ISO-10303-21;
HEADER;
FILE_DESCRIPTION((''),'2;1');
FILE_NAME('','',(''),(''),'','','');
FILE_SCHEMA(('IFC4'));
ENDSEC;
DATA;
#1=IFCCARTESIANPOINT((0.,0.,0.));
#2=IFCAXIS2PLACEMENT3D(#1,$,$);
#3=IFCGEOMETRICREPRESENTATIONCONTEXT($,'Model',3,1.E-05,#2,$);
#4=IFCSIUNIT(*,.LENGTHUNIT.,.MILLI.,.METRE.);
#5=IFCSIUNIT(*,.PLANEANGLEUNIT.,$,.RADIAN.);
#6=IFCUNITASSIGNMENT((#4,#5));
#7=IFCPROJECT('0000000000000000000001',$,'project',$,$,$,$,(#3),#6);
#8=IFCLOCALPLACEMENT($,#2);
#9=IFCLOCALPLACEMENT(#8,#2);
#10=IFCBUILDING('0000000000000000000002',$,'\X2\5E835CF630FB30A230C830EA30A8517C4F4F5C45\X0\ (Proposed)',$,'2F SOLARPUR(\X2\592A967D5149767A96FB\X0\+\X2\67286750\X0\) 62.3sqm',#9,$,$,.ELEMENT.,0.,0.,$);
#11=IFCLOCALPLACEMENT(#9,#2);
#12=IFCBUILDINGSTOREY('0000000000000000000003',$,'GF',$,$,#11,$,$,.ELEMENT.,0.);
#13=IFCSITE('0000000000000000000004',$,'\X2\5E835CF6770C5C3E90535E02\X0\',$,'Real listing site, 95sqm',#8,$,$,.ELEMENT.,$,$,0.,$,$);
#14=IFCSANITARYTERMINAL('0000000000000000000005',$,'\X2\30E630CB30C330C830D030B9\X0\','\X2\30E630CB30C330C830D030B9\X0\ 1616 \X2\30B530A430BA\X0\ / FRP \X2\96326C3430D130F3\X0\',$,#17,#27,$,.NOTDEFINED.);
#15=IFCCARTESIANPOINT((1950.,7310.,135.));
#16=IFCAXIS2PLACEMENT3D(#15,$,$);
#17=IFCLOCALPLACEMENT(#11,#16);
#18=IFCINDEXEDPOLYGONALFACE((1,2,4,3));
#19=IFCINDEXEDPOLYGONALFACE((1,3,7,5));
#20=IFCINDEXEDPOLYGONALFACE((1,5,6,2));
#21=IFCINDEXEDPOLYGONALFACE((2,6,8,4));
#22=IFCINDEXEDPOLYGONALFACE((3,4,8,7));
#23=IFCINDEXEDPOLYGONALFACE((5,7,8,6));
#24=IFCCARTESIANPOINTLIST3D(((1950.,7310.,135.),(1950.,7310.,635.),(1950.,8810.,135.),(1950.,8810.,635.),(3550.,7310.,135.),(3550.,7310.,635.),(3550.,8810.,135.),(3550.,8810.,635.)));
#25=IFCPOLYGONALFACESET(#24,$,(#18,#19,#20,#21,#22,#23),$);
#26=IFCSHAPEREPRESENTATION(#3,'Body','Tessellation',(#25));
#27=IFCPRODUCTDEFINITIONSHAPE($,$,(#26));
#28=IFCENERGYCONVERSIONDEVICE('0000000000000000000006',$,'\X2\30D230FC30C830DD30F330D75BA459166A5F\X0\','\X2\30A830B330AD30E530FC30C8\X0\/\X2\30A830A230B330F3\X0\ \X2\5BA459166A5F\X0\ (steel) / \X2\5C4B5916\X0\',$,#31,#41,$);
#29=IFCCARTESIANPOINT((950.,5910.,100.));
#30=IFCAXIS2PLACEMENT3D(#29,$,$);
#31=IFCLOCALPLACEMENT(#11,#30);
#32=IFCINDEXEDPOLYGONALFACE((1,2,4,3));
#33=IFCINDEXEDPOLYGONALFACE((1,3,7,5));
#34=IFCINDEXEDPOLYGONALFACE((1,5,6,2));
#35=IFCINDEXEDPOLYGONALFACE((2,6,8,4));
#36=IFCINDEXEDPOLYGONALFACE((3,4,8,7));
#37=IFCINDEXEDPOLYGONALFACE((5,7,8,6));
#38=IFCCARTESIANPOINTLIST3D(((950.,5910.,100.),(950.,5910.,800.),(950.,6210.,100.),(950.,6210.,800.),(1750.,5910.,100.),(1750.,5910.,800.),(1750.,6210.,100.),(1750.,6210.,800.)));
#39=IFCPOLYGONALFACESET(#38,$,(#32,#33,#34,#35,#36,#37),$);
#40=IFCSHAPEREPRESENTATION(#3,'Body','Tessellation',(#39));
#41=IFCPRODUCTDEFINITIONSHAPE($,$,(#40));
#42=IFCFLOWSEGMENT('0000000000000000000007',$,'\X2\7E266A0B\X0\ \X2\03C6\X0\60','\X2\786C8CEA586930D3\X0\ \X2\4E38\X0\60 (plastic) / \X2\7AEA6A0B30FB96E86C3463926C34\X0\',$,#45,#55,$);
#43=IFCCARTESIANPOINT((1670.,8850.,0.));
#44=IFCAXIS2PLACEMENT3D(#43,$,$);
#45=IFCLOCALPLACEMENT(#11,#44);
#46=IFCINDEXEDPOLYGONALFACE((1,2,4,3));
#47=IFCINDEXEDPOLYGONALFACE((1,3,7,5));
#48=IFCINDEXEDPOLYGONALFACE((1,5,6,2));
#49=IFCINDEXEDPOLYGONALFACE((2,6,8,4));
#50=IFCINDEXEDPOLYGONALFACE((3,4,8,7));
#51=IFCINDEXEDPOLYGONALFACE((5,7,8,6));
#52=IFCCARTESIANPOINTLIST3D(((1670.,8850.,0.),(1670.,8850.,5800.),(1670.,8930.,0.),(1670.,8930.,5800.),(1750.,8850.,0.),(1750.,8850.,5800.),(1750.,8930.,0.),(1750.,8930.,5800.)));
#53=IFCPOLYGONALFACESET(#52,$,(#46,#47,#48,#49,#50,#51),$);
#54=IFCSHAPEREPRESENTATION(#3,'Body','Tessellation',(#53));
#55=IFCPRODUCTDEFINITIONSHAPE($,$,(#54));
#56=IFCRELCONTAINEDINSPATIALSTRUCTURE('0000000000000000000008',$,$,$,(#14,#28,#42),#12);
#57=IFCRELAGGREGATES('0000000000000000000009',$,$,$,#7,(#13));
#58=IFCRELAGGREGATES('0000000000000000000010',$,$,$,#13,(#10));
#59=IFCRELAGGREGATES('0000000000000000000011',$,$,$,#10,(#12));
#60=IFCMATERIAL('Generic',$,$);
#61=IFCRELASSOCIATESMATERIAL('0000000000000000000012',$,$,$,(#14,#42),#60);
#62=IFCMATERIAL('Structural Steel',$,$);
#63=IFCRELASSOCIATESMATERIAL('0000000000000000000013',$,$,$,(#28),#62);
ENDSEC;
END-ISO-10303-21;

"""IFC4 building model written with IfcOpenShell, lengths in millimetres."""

from ifc_helpers import new_model, si_unit, frame, frame_2d, origin, place, context, project, spatial, rectangle, extrude, material, element, save


model = new_model("IFC4")

# Units and contexts
model_context = context("Model", 3, precision=1e-05, world=origin())
ifc_project = project(units=[si_unit("LENGTHUNIT", "METRE", prefix="MILLI"), si_unit("PLANEANGLEUNIT", "RADIAN")], contexts=[model_context])

# Site, building, storey
site_placement = place(None, origin())
site = spatial("IfcSite", under=ifc_project, at=site_placement, Name="広島県尾道市", ObjectType="Real listing site, 95sqm", CompositionType="ELEMENT", RefElevation=0.0)
building_placement = place(site_placement, origin())
building = spatial("IfcBuilding", under=site, at=building_placement, Name="広島・アトリエ兼住居 (Proposed)", ObjectType="2F SOLARPUR(太陽光発電+木材) 62.3sqm", CompositionType="ELEMENT", ElevationOfRefHeight=0.0, ElevationOfTerrain=0.0)
storey_placement = place(building_placement, origin())
storey = spatial("IfcBuildingStorey", under=building, at=storey_placement, Name="GF", CompositionType="ELEMENT", Elevation=0.0)

# Shared definitions
ifc_material_1 = material(Name="Generic")

# Sanitary terminal
sanitary_terminal_placement = place(storey_placement, frame((1950.0, 7310.0, 135.0)))
element("IfcSanitaryTerminal", 1, at=sanitary_terminal_placement, inside=storey, material=ifc_material_1, Name="ユニットバス", Description="ユニットバス 1616 サイズ / FRP 防水パン", PredefinedType="NOTDEFINED", context=model_context, shape_type="SweptSolid", body=[
    extrude(rectangle(XDim=1600.0, YDim=1500.0, at=frame_2d((800.0, 750.0))), frame((1950.0, 7310.0, 135.0)), (0.0, 0.0, 1.0), 500.0),
])

# Energy conversion device
ifc_material_2 = material(Name="Structural Steel")
energy_conversion_device_placement = place(storey_placement, frame((950.0, 5910.0, 100.0)))
element("IfcEnergyConversionDevice", 2, at=energy_conversion_device_placement, inside=storey, material=ifc_material_2, Name="ヒートポンプ室外機", Description="エコキュート/エアコン 室外機 (steel) / 屋外", context=model_context, shape_type="SweptSolid", body=[
    extrude(rectangle(XDim=800.0, YDim=300.0, at=frame_2d((400.0, 150.0))), frame((950.0, 5910.0, 100.0)), (0.0, 0.0, 1.0), 700.0),
])

# Flow segment
flow_segment_placement = place(storey_placement, frame((1670.0, 8850.0, 0.0)))
element("IfcFlowSegment", 3, at=flow_segment_placement, inside=storey, material=ifc_material_1, Name="縦樋 φ60", Description="硬質塩ビ 丸60 (plastic) / 竪樋・雨水排水", context=model_context, shape_type="SweptSolid", body=[
    extrude(rectangle(XDim=80.0, YDim=80.0, at=frame_2d((40.0, 40.0))), frame((1670.0, 8850.0, 0.0)), (0.0, 0.0, 1.0), 5800.0),
])

save(model, "model.ifc")
